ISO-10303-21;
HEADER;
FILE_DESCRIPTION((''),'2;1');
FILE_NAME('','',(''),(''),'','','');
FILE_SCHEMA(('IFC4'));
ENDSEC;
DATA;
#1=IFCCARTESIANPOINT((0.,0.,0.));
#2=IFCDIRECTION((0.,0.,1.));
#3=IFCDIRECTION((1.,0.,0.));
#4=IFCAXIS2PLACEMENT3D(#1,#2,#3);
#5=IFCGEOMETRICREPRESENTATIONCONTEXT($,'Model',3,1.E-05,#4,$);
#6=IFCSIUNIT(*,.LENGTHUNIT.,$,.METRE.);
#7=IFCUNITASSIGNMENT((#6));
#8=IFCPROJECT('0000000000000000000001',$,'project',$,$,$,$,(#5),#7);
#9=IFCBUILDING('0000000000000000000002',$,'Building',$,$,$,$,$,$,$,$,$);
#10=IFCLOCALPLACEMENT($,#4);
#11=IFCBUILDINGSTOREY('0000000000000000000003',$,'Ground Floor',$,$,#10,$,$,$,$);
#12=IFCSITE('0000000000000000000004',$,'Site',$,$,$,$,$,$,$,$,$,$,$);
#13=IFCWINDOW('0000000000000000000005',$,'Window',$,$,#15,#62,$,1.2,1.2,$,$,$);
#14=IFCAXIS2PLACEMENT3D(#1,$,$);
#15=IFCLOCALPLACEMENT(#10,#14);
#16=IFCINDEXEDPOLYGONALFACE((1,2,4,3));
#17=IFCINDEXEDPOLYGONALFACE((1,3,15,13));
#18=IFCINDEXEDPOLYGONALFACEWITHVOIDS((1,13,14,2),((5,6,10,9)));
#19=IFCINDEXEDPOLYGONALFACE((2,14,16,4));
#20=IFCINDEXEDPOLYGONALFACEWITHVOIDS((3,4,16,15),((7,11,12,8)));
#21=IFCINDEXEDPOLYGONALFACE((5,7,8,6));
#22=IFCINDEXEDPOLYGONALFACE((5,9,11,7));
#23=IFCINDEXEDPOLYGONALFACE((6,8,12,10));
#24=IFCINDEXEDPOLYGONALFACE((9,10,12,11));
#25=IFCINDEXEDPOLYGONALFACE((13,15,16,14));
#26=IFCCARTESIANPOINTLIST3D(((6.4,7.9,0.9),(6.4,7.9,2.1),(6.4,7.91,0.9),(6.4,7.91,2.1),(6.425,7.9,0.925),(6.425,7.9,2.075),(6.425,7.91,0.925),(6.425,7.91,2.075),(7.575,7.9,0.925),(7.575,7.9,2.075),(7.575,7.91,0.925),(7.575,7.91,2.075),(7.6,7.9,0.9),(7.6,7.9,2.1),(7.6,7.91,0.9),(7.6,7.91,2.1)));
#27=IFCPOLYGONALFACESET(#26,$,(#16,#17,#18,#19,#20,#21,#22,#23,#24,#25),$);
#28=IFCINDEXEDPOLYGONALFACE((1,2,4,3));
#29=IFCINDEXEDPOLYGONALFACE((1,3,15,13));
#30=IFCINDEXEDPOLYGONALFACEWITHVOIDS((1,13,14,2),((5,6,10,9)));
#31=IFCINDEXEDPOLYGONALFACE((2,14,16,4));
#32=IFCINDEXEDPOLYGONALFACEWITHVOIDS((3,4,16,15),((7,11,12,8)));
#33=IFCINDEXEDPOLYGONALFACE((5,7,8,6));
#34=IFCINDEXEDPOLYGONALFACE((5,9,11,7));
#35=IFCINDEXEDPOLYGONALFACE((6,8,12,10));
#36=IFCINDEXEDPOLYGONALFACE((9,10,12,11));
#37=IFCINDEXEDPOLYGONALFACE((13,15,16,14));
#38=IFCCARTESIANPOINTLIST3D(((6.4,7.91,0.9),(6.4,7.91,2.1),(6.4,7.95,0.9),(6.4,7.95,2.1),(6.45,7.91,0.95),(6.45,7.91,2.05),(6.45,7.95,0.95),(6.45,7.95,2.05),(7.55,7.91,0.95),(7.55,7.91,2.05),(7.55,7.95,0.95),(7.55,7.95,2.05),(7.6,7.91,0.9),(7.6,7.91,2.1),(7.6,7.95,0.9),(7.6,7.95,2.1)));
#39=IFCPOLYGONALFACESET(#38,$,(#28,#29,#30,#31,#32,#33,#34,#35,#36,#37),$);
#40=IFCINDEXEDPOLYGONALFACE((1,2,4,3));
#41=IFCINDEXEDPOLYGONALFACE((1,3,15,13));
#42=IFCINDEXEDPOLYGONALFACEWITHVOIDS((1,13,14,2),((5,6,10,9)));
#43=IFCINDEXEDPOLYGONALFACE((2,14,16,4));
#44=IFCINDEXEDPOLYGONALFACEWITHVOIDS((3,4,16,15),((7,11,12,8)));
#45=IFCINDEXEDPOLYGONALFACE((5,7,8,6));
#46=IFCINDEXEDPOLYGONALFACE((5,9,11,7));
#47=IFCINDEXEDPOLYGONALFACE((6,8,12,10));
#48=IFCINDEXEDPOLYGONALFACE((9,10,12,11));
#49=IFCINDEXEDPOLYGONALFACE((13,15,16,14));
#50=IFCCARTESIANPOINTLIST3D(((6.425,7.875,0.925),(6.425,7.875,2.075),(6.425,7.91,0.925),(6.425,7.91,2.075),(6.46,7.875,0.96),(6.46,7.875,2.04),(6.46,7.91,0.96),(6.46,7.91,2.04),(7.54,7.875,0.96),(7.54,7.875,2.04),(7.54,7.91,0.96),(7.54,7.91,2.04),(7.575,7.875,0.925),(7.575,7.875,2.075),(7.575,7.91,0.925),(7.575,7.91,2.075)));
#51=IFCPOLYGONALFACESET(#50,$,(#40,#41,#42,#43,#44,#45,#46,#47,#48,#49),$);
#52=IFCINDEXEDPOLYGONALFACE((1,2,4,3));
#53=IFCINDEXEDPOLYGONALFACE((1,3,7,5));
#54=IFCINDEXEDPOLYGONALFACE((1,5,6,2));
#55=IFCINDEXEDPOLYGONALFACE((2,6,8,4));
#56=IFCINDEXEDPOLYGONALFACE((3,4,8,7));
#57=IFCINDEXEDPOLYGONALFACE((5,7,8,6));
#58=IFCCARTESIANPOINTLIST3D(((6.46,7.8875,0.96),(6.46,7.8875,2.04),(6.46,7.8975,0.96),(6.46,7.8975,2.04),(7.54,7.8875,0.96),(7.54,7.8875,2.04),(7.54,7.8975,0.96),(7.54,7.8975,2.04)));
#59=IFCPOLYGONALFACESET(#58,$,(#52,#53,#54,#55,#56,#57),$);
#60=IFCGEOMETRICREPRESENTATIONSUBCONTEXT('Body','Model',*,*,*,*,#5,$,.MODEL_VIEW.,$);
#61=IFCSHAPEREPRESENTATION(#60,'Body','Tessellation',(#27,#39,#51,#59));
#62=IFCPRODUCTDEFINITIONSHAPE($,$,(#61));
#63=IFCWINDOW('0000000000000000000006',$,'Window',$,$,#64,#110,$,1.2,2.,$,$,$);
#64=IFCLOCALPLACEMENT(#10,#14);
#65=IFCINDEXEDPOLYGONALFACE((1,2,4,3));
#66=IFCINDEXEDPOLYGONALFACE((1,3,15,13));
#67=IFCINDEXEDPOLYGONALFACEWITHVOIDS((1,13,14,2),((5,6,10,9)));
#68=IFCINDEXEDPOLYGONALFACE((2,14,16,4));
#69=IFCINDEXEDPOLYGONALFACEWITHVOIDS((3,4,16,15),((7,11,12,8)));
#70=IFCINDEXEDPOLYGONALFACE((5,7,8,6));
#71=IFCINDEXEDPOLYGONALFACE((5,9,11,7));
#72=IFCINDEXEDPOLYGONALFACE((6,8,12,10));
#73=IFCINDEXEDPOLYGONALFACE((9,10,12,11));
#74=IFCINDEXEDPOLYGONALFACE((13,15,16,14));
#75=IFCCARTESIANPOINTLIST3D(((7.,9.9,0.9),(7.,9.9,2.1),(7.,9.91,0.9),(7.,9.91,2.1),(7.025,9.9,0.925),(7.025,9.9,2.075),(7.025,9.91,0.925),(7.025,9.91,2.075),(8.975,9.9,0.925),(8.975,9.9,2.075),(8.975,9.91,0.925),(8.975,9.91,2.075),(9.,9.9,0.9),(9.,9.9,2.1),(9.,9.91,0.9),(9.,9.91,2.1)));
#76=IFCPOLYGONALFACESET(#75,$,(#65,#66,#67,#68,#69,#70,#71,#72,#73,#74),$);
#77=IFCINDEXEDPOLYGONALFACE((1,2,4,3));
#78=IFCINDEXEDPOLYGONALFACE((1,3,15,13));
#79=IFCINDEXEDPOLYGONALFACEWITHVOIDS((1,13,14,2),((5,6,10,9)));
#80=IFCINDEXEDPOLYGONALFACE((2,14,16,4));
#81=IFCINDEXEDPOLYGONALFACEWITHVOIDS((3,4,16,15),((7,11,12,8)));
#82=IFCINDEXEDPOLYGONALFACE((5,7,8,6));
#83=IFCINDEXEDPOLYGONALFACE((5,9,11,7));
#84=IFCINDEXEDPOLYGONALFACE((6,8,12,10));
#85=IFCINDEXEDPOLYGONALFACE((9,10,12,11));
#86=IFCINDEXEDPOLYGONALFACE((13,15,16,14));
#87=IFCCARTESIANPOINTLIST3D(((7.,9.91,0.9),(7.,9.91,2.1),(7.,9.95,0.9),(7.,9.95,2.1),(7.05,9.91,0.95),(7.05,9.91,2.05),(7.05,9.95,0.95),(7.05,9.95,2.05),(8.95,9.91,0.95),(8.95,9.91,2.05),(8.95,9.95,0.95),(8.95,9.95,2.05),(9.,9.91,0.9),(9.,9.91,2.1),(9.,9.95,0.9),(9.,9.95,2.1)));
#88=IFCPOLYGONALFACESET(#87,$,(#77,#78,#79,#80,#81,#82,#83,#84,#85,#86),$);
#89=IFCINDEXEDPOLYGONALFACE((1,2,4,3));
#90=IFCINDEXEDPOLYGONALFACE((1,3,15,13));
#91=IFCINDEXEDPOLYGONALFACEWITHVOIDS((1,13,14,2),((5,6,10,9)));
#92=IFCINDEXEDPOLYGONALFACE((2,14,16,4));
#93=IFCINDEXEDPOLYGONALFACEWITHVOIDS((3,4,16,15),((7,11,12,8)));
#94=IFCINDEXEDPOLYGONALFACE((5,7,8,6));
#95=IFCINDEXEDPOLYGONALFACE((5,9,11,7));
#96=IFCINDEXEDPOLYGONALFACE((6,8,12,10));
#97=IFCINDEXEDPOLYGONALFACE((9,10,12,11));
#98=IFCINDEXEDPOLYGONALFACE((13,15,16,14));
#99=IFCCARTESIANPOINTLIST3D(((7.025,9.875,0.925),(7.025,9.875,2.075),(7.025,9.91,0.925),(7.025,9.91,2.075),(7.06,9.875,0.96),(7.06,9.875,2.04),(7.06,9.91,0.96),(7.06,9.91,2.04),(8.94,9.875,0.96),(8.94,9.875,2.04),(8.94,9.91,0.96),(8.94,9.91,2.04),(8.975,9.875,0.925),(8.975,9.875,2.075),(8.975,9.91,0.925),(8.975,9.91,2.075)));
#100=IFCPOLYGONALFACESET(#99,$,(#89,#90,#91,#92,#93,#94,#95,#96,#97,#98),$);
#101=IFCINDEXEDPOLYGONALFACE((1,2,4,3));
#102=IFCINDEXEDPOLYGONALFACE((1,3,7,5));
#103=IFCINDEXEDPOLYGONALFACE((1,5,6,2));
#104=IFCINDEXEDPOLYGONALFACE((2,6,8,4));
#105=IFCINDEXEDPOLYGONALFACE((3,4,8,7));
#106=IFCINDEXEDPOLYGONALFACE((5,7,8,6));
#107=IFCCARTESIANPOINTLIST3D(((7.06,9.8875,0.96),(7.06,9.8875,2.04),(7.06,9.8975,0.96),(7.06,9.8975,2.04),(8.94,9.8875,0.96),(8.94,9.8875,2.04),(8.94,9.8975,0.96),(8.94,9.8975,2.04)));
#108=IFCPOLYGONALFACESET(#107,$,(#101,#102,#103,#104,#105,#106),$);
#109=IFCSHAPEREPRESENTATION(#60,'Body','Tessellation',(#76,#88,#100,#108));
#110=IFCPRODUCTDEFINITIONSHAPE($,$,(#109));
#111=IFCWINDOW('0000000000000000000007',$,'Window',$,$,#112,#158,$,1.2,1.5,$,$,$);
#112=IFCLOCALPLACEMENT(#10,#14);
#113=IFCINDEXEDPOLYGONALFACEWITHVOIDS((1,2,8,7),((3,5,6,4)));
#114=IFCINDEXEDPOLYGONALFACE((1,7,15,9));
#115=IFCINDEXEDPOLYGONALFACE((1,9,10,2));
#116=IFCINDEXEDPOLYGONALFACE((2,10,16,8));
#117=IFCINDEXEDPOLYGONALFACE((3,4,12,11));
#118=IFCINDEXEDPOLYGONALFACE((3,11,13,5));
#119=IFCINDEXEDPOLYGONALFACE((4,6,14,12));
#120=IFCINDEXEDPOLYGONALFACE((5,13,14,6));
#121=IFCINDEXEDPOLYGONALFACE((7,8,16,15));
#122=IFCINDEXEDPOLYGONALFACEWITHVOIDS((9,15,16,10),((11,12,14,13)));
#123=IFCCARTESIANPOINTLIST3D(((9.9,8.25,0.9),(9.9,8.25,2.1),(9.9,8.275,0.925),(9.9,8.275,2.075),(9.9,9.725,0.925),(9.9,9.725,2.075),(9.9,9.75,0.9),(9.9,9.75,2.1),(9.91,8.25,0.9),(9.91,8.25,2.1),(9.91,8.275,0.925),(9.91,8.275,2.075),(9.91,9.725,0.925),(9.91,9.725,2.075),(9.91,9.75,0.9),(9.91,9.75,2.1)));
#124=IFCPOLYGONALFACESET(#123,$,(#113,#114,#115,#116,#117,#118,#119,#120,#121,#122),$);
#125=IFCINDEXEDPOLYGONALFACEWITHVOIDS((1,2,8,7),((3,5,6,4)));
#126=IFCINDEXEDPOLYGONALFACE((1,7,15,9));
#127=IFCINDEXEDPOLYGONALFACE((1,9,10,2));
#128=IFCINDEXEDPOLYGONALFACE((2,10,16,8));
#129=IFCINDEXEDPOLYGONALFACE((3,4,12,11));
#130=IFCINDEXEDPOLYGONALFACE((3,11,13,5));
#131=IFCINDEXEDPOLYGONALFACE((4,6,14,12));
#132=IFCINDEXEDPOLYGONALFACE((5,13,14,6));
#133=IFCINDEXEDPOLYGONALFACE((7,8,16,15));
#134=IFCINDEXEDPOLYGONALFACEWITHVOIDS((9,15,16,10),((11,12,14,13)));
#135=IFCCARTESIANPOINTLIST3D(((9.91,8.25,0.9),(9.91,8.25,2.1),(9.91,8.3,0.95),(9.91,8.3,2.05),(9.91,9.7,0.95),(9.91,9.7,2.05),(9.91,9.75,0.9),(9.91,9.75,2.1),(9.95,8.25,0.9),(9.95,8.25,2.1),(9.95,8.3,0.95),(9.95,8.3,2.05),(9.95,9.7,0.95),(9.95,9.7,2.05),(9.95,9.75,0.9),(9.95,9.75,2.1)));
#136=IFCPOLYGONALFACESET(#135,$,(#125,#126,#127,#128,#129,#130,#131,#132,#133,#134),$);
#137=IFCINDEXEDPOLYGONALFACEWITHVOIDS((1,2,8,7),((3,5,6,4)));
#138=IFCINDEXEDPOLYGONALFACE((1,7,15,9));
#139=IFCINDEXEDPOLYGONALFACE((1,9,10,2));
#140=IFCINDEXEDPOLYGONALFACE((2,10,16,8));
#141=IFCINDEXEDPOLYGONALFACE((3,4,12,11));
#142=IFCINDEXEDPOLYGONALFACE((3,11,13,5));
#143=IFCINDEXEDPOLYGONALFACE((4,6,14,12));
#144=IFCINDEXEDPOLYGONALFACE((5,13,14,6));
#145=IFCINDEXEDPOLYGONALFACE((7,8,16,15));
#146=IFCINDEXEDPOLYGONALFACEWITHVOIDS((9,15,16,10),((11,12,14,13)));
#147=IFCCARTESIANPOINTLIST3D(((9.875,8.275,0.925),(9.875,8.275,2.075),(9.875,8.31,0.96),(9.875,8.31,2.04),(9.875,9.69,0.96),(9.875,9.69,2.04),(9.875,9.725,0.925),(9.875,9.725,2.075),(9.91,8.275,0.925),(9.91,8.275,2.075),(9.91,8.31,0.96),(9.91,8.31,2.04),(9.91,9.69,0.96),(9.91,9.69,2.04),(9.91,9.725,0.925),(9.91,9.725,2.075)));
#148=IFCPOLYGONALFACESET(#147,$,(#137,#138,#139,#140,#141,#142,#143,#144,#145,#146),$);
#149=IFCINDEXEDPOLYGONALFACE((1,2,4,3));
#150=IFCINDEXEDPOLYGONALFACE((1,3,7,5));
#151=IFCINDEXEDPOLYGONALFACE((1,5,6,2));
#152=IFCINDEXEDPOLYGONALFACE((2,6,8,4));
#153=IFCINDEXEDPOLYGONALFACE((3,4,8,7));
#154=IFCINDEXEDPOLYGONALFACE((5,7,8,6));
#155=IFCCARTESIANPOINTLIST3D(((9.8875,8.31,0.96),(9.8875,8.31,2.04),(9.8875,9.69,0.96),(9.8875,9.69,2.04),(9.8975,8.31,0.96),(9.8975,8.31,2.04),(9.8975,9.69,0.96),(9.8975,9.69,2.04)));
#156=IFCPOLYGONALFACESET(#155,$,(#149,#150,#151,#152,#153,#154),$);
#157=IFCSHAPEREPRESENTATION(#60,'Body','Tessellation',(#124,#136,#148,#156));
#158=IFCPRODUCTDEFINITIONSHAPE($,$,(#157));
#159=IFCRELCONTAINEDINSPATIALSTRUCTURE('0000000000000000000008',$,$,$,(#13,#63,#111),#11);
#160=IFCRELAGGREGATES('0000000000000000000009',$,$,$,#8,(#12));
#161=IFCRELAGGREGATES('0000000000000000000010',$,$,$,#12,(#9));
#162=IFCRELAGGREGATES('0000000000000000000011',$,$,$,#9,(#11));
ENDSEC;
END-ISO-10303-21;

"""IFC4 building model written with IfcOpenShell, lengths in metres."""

from ifc_helpers import new_model, si_unit, frame, origin_with_axes, place, context, subcontext, project, spatial, line, indexed_curve, outline, extrude, element, save


model = new_model("IFC4")

# Units and contexts
model_context = context("Model", 3, precision=1e-05, world=origin_with_axes())
body_context = subcontext(model_context, "Body", "Model", "MODEL_VIEW")
ifc_project = project(units=[si_unit("LENGTHUNIT", "METRE")], contexts=[model_context])

# Site, building, storey
site = spatial("IfcSite", under=ifc_project, Name="Site")
building = spatial("IfcBuilding", under=site, Name="Building")
storey_placement = place(None, origin_with_axes())
storey = spatial("IfcBuildingStorey", under=building, at=storey_placement, Name="Ground Floor")

# Windows
window_1_placement = place(storey_placement, frame((7.6, 8.0, 0.9), z_axis=(0.0, 0.0, 1.0), x_axis=(-1.0, 0.0, 0.0)))
element("IfcWindow", 1, at=window_1_placement, inside=storey, Name="Window", OverallHeight=1.2, OverallWidth=1.2, context=body_context, shape_type="SweptSolid", body=[
    extrude(outline(indexed_curve([(0.0, 0.0), (1.2, 0.0), (1.2, 1.2), (0.0, 1.2)], segments=[line(1, 2, 3, 4, 1)]), holes=[indexed_curve([(0.025, 0.025), (1.175, 0.025), (1.175, 1.175), (0.025, 1.175)], segments=[line(1, 2, 3, 4, 1)])]), frame((0.0, 0.09, 0.0), z_axis=(0.0, -1.0, 0.0), x_axis=(1.0, 0.0, 0.0)), (0.0, 0.0, -1.0), 0.01),
    extrude(outline(indexed_curve([(0.0, 0.0), (1.2, 0.0), (1.2, 1.2), (0.0, 1.2)], segments=[line(1, 2, 3, 4, 1)]), holes=[indexed_curve([(0.05, 0.05), (1.15, 0.05), (1.15, 1.15), (0.05, 1.15)], segments=[line(1, 2, 3, 4, 1)])]), frame((0.0, 0.05, 0.0), z_axis=(0.0, -1.0, 0.0), x_axis=(1.0, 0.0, 0.0)), (0.0, 0.0, -1.0), 0.04),
    extrude(outline(indexed_curve([(0.0, 0.0), (1.15, 0.0), (1.15, 1.15), (0.0, 1.15)], segments=[line(1, 2, 3, 4, 1)]), holes=[indexed_curve([(0.035, 0.035), (1.115, 0.035), (1.115, 1.115), (0.035, 1.115)], segments=[line(1, 2, 3, 4, 1)])]), frame((0.025, 0.09, 0.025), z_axis=(0.0, -1.0, 0.0), x_axis=(1.0, 0.0, 0.0)), (0.0, 0.0, -1.0), 0.035),
    extrude(outline(indexed_curve([(0.035, 0.035), (1.115, 0.035), (1.115, 1.115), (0.035, 1.115)], segments=[line(1, 2, 3, 4, 1)])), frame((0.025, 0.1025, 0.025), z_axis=(0.0, -1.0, 0.0), x_axis=(1.0, 0.0, 0.0)), (0.0, 0.0, -1.0), 0.01),
])
window_2_placement = place(storey_placement, frame((9.0, 10.0, 0.9), z_axis=(0.0, 0.0, 1.0), x_axis=(-1.0, 0.0, 0.0)))
element("IfcWindow", 2, at=window_2_placement, inside=storey, Name="Window", OverallHeight=1.2, OverallWidth=2.0, context=body_context, shape_type="SweptSolid", body=[
    extrude(outline(indexed_curve([(0.0, 0.0), (2.0, 0.0), (2.0, 1.2), (0.0, 1.2)], segments=[line(1, 2, 3, 4, 1)]), holes=[indexed_curve([(0.025, 0.025), (1.975, 0.025), (1.975, 1.175), (0.025, 1.175)], segments=[line(1, 2, 3, 4, 1)])]), frame((0.0, 0.09, 0.0), z_axis=(0.0, -1.0, 0.0), x_axis=(1.0, 0.0, 0.0)), (0.0, 0.0, -1.0), 0.01),
    extrude(outline(indexed_curve([(0.0, 0.0), (2.0, 0.0), (2.0, 1.2), (0.0, 1.2)], segments=[line(1, 2, 3, 4, 1)]), holes=[indexed_curve([(0.05, 0.05), (1.95, 0.05), (1.95, 1.15), (0.05, 1.15)], segments=[line(1, 2, 3, 4, 1)])]), frame((0.0, 0.05, 0.0), z_axis=(0.0, -1.0, 0.0), x_axis=(1.0, 0.0, 0.0)), (0.0, 0.0, -1.0), 0.04),
    extrude(outline(indexed_curve([(0.0, 0.0), (1.95, 0.0), (1.95, 1.15), (0.0, 1.15)], segments=[line(1, 2, 3, 4, 1)]), holes=[indexed_curve([(0.035, 0.035), (1.915, 0.035), (1.915, 1.115), (0.035, 1.115)], segments=[line(1, 2, 3, 4, 1)])]), frame((0.025, 0.09, 0.025), z_axis=(0.0, -1.0, 0.0), x_axis=(1.0, 0.0, 0.0)), (0.0, 0.0, -1.0), 0.035),
    extrude(outline(indexed_curve([(0.035, 0.035), (1.915, 0.035), (1.915, 1.115), (0.035, 1.115)], segments=[line(1, 2, 3, 4, 1)])), frame((0.025, 0.1025, 0.025), z_axis=(0.0, -1.0, 0.0), x_axis=(1.0, 0.0, 0.0)), (0.0, 0.0, -1.0), 0.01),
])
window_3_placement = place(storey_placement, frame((10.0, 8.25, 0.9), z_axis=(0.0, 0.0, 1.0), x_axis=(0.0, 1.0, 0.0)))
element("IfcWindow", 3, at=window_3_placement, inside=storey, Name="Window", OverallHeight=1.2, OverallWidth=1.5, context=body_context, shape_type="SweptSolid", body=[
    extrude(outline(indexed_curve([(0.0, 0.0), (1.5, 0.0), (1.5, 1.2), (0.0, 1.2)], segments=[line(1, 2, 3, 4, 1)]), holes=[indexed_curve([(0.025, 0.025), (1.475, 0.025), (1.475, 1.175), (0.025, 1.175)], segments=[line(1, 2, 3, 4, 1)])]), frame((0.0, 0.09, 0.0), z_axis=(0.0, -1.0, 0.0), x_axis=(1.0, 0.0, 0.0)), (0.0, 0.0, -1.0), 0.01),
    extrude(outline(indexed_curve([(0.0, 0.0), (1.5, 0.0), (1.5, 1.2), (0.0, 1.2)], segments=[line(1, 2, 3, 4, 1)]), holes=[indexed_curve([(0.05, 0.05), (1.45, 0.05), (1.45, 1.15), (0.05, 1.15)], segments=[line(1, 2, 3, 4, 1)])]), frame((0.0, 0.05, 0.0), z_axis=(0.0, -1.0, 0.0), x_axis=(1.0, 0.0, 0.0)), (0.0, 0.0, -1.0), 0.04),
    extrude(outline(indexed_curve([(0.0, 0.0), (1.45, 0.0), (1.45, 1.15), (0.0, 1.15)], segments=[line(1, 2, 3, 4, 1)]), holes=[indexed_curve([(0.035, 0.035), (1.415, 0.035), (1.415, 1.115), (0.035, 1.115)], segments=[line(1, 2, 3, 4, 1)])]), frame((0.025, 0.09, 0.025), z_axis=(0.0, -1.0, 0.0), x_axis=(1.0, 0.0, 0.0)), (0.0, 0.0, -1.0), 0.035),
    extrude(outline(indexed_curve([(0.035, 0.035), (1.415, 0.035), (1.415, 1.115), (0.035, 1.115)], segments=[line(1, 2, 3, 4, 1)])), frame((0.025, 0.1025, 0.025), z_axis=(0.0, -1.0, 0.0), x_axis=(1.0, 0.0, 0.0)), (0.0, 0.0, -1.0), 0.01),
])

save(model, "model.ifc")
